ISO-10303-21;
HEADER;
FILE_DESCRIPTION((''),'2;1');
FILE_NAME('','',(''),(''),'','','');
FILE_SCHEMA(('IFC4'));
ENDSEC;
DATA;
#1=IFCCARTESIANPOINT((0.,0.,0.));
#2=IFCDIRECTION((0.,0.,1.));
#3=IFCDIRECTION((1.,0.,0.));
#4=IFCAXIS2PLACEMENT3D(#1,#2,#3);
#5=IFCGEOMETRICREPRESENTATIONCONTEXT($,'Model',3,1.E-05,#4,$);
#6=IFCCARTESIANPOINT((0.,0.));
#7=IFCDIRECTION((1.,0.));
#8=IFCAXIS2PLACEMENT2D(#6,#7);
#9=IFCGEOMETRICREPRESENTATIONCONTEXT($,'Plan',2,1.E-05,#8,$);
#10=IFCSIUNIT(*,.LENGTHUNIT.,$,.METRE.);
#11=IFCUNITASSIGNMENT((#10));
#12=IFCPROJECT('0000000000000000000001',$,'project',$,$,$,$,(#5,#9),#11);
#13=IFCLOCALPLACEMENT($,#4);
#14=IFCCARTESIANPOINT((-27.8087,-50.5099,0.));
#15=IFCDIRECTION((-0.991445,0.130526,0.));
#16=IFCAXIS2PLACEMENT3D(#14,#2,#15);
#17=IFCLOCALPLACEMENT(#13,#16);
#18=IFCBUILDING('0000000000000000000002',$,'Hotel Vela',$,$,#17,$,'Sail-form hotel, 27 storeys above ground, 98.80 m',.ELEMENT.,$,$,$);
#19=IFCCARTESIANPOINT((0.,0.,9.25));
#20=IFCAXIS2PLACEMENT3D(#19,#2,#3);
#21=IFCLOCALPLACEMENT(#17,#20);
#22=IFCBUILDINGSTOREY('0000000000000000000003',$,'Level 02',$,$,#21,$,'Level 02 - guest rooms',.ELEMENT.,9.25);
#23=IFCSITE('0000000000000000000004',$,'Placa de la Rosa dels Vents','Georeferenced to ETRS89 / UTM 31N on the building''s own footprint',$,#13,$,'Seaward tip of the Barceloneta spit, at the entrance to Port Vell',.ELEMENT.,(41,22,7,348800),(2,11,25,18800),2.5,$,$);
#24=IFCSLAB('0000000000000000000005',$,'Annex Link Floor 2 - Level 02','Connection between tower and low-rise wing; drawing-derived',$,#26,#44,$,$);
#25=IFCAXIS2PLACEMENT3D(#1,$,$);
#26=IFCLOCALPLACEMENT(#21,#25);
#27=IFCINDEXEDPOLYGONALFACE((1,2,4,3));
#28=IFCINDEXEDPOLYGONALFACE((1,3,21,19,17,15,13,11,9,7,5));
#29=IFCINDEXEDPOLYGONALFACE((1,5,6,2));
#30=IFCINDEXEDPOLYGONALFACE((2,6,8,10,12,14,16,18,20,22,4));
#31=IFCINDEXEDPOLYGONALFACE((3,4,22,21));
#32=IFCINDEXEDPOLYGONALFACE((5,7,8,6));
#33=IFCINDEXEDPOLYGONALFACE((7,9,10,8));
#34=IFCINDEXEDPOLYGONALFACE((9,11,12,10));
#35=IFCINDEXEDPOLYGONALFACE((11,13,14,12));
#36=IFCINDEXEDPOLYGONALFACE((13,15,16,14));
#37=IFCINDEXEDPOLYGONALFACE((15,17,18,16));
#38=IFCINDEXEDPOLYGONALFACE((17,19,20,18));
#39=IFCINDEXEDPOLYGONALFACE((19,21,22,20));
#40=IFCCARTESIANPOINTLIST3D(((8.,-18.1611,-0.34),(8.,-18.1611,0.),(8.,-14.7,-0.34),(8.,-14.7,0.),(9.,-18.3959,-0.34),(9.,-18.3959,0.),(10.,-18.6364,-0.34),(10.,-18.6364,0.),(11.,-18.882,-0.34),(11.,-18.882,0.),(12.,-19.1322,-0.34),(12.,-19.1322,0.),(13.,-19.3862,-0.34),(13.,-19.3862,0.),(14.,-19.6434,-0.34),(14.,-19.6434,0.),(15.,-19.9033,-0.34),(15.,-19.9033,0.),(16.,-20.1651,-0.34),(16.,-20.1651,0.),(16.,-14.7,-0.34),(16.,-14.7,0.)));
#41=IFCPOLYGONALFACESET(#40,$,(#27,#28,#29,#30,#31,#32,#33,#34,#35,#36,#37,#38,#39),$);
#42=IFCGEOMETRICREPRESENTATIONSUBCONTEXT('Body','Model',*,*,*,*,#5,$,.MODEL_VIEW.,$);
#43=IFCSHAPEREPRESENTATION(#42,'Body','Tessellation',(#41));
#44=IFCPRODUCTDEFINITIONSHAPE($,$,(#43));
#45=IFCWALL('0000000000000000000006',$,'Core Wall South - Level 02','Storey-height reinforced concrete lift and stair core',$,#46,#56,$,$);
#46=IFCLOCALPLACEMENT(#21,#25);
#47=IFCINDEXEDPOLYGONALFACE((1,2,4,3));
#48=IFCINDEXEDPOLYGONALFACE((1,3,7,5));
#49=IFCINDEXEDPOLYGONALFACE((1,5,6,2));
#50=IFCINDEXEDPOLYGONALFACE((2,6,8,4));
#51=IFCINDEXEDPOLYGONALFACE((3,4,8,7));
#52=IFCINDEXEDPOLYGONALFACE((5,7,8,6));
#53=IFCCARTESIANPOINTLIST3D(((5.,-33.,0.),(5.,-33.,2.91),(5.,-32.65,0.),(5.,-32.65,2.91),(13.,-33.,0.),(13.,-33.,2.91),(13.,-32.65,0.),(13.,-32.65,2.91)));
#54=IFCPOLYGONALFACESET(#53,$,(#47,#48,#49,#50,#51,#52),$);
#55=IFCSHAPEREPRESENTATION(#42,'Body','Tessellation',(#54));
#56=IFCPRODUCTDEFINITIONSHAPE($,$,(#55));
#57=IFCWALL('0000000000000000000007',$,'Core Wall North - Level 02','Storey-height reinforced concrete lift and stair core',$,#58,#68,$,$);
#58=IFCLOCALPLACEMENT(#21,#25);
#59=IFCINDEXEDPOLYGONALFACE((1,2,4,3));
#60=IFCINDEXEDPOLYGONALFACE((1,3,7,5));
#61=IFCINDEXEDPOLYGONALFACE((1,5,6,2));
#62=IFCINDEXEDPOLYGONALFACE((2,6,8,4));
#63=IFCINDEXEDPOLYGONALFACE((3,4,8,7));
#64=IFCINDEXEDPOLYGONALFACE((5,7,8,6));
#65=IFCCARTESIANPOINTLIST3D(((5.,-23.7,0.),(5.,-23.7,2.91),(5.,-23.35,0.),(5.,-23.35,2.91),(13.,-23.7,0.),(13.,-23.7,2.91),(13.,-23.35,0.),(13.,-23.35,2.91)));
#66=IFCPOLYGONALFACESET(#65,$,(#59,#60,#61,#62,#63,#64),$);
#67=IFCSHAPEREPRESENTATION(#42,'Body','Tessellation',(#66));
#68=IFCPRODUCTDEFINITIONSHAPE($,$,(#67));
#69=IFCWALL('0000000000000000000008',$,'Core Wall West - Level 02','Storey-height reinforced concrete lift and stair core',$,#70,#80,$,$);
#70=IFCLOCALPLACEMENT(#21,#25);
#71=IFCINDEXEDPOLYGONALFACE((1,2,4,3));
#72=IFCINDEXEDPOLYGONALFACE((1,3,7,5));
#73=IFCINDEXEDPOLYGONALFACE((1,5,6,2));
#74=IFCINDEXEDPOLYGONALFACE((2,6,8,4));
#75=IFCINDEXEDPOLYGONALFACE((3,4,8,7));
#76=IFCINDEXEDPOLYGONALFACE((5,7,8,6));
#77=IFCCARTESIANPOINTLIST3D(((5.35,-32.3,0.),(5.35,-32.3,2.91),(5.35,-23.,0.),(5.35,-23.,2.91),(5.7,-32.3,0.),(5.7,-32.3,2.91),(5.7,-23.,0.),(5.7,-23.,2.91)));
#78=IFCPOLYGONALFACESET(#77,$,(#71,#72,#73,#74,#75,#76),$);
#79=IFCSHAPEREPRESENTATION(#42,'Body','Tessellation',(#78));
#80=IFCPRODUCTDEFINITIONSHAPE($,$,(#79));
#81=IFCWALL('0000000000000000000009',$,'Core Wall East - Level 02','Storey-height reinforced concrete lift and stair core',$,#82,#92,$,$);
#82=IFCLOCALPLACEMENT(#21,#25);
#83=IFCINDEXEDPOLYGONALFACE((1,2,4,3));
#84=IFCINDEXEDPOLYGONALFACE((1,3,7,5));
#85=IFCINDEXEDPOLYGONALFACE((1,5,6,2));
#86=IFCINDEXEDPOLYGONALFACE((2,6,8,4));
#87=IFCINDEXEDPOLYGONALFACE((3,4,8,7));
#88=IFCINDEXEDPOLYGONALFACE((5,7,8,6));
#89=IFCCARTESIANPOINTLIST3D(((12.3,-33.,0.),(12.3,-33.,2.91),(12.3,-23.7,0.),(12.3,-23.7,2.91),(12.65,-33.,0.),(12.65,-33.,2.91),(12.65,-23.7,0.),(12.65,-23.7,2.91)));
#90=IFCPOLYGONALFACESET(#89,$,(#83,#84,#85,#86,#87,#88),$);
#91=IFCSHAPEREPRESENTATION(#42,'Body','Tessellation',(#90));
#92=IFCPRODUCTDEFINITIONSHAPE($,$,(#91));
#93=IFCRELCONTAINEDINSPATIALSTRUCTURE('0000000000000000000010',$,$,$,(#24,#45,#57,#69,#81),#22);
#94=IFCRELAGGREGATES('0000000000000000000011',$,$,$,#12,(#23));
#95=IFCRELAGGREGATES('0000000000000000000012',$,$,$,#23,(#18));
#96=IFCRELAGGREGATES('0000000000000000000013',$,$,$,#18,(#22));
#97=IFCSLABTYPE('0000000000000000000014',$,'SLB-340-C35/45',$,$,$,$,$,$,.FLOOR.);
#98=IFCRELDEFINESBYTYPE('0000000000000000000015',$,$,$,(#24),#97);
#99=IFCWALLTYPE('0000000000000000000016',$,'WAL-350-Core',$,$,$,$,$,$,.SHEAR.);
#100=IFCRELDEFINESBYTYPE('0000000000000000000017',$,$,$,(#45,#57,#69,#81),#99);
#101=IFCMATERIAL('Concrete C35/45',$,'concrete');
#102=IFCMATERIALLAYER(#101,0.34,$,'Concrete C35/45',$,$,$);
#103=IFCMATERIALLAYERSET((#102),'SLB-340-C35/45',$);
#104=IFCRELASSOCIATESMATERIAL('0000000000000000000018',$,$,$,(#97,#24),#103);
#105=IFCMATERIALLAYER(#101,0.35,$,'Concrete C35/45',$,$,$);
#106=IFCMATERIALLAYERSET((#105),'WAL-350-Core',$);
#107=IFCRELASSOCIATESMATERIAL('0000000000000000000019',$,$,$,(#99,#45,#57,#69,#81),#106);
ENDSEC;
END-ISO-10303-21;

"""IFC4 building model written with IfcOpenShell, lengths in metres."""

from ifc_helpers import new_model, si_unit, frame, origin_with_axes, origin_2d_with_axis, place, context, subcontext, project, spatial, line, indexed_curve, outline, extrude, material, layer, layer_set, layer_usage, type_object, element, save


model = new_model("IFC4")

# Units and contexts
model_context = context("Model", 3, precision=1e-05, world=origin_with_axes())
plan_context = context("Plan", 2, precision=1e-05, world=origin_2d_with_axis())
body_context = subcontext(model_context, "Body", "Model", "MODEL_VIEW")
ifc_project = project(units=[si_unit("LENGTHUNIT", "METRE")], contexts=[model_context, plan_context])

# Site, building, storey
site_placement = place(None, origin_with_axes())
site = spatial("IfcSite", under=ifc_project, at=site_placement, Name="Placa de la Rosa dels Vents", Description="Georeferenced to ETRS89 / UTM 31N on the building's own footprint", LongName="Seaward tip of the Barceloneta spit, at the entrance to Port Vell", CompositionType="ELEMENT", RefLatitude=(41, 22, 7, 348800), RefLongitude=(2, 11, 25, 18800), RefElevation=2.5)
building_placement = place(site_placement, frame((-27.8087, -50.5099, 0.0), z_axis=(0.0, 0.0, 1.0), x_axis=(-0.991445, 0.130526, 0.0)))
building = spatial("IfcBuilding", under=site, at=building_placement, Name="Hotel Vela", LongName="Sail-form hotel, 27 storeys above ground, 98.80 m", CompositionType="ELEMENT")
storey_placement = place(building_placement, frame((0.0, 0.0, 9.25), z_axis=(0.0, 0.0, 1.0), x_axis=(1.0, 0.0, 0.0)))
storey = spatial("IfcBuildingStorey", under=building, at=storey_placement, Name="Level 02", LongName="Level 02 - guest rooms", CompositionType="ELEMENT", Elevation=9.25)

# Shared definitions
ifc_material = material(Name="Concrete C35/45", Category="concrete")

# Shared definitions
ifc_layer_1 = layer(ifc_material, 0.34, Name="Concrete C35/45")
ifc_layer_set_1 = layer_set([ifc_layer_1], Name="SLB-340-C35/45")
slab_type = type_object("IfcSlabType", Name="SLB-340-C35/45", PredefinedType="FLOOR", material=ifc_layer_set_1)

# Slab
ifc_layer_usage_1 = layer_usage(ifc_layer_set_1, "AXIS3", "POSITIVE", 0.0)
slab_1_placement = place(storey_placement, frame((0.0, 0.0, -0.34), z_axis=(0.0, 0.0, 1.0), x_axis=(1.0, 0.0, 0.0)))
element("IfcSlab", 1, at=slab_1_placement, inside=storey, type_object=slab_type, material=ifc_layer_usage_1, Name="Annex Link Floor 2 - Level 02", Description="Connection between tower and low-rise wing; drawing-derived", context=body_context, shape_type="SweptSolid", body=[
    extrude(outline(indexed_curve([(8.0, -18.1611), (9.0, -18.3959), (10.0, -18.6364), (11.0, -18.882), (12.0, -19.1322), (13.0, -19.3862), (14.0, -19.6434), (15.0, -19.9033), (16.0, -20.1651), (16.0, -14.7), (8.0, -14.7)], segments=[line(1, 2, 3, 4, 5, 6, 7, 8, 9, 10, 11, 1)])), origin_with_axes(), (0.0, 0.0, 1.0), 0.34),
])

# Walls
ifc_layer_2 = layer(ifc_material, 0.35, Name="Concrete C35/45")
ifc_layer_set_2 = layer_set([ifc_layer_2], Name="WAL-350-Core")
ifc_layer_usage_2 = layer_usage(ifc_layer_set_2, "AXIS2", "POSITIVE", 0.0)
wall_type = type_object("IfcWallType", Name="WAL-350-Core", PredefinedType="SHEAR", material=ifc_layer_set_2)
wall_1_placement = place(storey_placement, frame((5.0, -33.0, 0.0), z_axis=(0.0, 0.0, 1.0), x_axis=(1.0, 0.0, 0.0)))
element("IfcWall", 2, at=wall_1_placement, inside=storey, type_object=wall_type, material=ifc_layer_usage_2, Name="Core Wall South - Level 02", Description="Storey-height reinforced concrete lift and stair core", context=body_context, shape_type="SweptSolid", body=[
    extrude(outline(indexed_curve([(0.0, 0.0), (8.0, 0.0), (8.0, 0.35), (0.0, 0.35)], segments=[line(1, 2, 3, 4, 1)])), origin_with_axes(), (0.0, 0.0, 1.0), 2.91),
])
ifc_layer_usage_3 = layer_usage(ifc_layer_set_2, "AXIS2", "POSITIVE", 0.0)
wall_2_placement = place(storey_placement, frame((13.0, -23.35, 0.0), z_axis=(0.0, 0.0, 1.0), x_axis=(-1.0, 0.0, 0.0)))
element("IfcWall", 3, at=wall_2_placement, inside=storey, type_object=wall_type, material=ifc_layer_usage_3, Name="Core Wall North - Level 02", Description="Storey-height reinforced concrete lift and stair core", context=body_context, shape_type="SweptSolid", body=[
    extrude(outline(indexed_curve([(0.0, 0.0), (8.0, 0.0), (8.0, 0.35), (0.0, 0.35)], segments=[line(1, 2, 3, 4, 1)])), origin_with_axes(), (0.0, 0.0, 1.0), 2.91),
])
ifc_layer_usage_4 = layer_usage(ifc_layer_set_2, "AXIS2", "POSITIVE", 0.0)
wall_3_placement = place(storey_placement, frame((5.35, -23.0, 0.0), z_axis=(0.0, 0.0, 1.0), x_axis=(0.0, -1.0, 0.0)))
element("IfcWall", 4, at=wall_3_placement, inside=storey, type_object=wall_type, material=ifc_layer_usage_4, Name="Core Wall West - Level 02", Description="Storey-height reinforced concrete lift and stair core", context=body_context, shape_type="SweptSolid", body=[
    extrude(outline(indexed_curve([(0.0, 0.0), (9.3, 0.0), (9.3, 0.35), (0.0, 0.35)], segments=[line(1, 2, 3, 4, 1)])), origin_with_axes(), (0.0, 0.0, 1.0), 2.91),
])
ifc_layer_usage_5 = layer_usage(ifc_layer_set_2, "AXIS2", "POSITIVE", 0.0)
wall_4_placement = place(storey_placement, frame((12.65, -33.0, 0.0), z_axis=(0.0, 0.0, 1.0), x_axis=(0.0, 1.0, 0.0)))
element("IfcWall", 5, at=wall_4_placement, inside=storey, type_object=wall_type, material=ifc_layer_usage_5, Name="Core Wall East - Level 02", Description="Storey-height reinforced concrete lift and stair core", context=body_context, shape_type="SweptSolid", body=[
    extrude(outline(indexed_curve([(0.0, 0.0), (9.3, 0.0), (9.3, 0.35), (0.0, 0.35)], segments=[line(1, 2, 3, 4, 1)])), origin_with_axes(), (0.0, 0.0, 1.0), 2.91),
])

save(model, "model.ifc")
